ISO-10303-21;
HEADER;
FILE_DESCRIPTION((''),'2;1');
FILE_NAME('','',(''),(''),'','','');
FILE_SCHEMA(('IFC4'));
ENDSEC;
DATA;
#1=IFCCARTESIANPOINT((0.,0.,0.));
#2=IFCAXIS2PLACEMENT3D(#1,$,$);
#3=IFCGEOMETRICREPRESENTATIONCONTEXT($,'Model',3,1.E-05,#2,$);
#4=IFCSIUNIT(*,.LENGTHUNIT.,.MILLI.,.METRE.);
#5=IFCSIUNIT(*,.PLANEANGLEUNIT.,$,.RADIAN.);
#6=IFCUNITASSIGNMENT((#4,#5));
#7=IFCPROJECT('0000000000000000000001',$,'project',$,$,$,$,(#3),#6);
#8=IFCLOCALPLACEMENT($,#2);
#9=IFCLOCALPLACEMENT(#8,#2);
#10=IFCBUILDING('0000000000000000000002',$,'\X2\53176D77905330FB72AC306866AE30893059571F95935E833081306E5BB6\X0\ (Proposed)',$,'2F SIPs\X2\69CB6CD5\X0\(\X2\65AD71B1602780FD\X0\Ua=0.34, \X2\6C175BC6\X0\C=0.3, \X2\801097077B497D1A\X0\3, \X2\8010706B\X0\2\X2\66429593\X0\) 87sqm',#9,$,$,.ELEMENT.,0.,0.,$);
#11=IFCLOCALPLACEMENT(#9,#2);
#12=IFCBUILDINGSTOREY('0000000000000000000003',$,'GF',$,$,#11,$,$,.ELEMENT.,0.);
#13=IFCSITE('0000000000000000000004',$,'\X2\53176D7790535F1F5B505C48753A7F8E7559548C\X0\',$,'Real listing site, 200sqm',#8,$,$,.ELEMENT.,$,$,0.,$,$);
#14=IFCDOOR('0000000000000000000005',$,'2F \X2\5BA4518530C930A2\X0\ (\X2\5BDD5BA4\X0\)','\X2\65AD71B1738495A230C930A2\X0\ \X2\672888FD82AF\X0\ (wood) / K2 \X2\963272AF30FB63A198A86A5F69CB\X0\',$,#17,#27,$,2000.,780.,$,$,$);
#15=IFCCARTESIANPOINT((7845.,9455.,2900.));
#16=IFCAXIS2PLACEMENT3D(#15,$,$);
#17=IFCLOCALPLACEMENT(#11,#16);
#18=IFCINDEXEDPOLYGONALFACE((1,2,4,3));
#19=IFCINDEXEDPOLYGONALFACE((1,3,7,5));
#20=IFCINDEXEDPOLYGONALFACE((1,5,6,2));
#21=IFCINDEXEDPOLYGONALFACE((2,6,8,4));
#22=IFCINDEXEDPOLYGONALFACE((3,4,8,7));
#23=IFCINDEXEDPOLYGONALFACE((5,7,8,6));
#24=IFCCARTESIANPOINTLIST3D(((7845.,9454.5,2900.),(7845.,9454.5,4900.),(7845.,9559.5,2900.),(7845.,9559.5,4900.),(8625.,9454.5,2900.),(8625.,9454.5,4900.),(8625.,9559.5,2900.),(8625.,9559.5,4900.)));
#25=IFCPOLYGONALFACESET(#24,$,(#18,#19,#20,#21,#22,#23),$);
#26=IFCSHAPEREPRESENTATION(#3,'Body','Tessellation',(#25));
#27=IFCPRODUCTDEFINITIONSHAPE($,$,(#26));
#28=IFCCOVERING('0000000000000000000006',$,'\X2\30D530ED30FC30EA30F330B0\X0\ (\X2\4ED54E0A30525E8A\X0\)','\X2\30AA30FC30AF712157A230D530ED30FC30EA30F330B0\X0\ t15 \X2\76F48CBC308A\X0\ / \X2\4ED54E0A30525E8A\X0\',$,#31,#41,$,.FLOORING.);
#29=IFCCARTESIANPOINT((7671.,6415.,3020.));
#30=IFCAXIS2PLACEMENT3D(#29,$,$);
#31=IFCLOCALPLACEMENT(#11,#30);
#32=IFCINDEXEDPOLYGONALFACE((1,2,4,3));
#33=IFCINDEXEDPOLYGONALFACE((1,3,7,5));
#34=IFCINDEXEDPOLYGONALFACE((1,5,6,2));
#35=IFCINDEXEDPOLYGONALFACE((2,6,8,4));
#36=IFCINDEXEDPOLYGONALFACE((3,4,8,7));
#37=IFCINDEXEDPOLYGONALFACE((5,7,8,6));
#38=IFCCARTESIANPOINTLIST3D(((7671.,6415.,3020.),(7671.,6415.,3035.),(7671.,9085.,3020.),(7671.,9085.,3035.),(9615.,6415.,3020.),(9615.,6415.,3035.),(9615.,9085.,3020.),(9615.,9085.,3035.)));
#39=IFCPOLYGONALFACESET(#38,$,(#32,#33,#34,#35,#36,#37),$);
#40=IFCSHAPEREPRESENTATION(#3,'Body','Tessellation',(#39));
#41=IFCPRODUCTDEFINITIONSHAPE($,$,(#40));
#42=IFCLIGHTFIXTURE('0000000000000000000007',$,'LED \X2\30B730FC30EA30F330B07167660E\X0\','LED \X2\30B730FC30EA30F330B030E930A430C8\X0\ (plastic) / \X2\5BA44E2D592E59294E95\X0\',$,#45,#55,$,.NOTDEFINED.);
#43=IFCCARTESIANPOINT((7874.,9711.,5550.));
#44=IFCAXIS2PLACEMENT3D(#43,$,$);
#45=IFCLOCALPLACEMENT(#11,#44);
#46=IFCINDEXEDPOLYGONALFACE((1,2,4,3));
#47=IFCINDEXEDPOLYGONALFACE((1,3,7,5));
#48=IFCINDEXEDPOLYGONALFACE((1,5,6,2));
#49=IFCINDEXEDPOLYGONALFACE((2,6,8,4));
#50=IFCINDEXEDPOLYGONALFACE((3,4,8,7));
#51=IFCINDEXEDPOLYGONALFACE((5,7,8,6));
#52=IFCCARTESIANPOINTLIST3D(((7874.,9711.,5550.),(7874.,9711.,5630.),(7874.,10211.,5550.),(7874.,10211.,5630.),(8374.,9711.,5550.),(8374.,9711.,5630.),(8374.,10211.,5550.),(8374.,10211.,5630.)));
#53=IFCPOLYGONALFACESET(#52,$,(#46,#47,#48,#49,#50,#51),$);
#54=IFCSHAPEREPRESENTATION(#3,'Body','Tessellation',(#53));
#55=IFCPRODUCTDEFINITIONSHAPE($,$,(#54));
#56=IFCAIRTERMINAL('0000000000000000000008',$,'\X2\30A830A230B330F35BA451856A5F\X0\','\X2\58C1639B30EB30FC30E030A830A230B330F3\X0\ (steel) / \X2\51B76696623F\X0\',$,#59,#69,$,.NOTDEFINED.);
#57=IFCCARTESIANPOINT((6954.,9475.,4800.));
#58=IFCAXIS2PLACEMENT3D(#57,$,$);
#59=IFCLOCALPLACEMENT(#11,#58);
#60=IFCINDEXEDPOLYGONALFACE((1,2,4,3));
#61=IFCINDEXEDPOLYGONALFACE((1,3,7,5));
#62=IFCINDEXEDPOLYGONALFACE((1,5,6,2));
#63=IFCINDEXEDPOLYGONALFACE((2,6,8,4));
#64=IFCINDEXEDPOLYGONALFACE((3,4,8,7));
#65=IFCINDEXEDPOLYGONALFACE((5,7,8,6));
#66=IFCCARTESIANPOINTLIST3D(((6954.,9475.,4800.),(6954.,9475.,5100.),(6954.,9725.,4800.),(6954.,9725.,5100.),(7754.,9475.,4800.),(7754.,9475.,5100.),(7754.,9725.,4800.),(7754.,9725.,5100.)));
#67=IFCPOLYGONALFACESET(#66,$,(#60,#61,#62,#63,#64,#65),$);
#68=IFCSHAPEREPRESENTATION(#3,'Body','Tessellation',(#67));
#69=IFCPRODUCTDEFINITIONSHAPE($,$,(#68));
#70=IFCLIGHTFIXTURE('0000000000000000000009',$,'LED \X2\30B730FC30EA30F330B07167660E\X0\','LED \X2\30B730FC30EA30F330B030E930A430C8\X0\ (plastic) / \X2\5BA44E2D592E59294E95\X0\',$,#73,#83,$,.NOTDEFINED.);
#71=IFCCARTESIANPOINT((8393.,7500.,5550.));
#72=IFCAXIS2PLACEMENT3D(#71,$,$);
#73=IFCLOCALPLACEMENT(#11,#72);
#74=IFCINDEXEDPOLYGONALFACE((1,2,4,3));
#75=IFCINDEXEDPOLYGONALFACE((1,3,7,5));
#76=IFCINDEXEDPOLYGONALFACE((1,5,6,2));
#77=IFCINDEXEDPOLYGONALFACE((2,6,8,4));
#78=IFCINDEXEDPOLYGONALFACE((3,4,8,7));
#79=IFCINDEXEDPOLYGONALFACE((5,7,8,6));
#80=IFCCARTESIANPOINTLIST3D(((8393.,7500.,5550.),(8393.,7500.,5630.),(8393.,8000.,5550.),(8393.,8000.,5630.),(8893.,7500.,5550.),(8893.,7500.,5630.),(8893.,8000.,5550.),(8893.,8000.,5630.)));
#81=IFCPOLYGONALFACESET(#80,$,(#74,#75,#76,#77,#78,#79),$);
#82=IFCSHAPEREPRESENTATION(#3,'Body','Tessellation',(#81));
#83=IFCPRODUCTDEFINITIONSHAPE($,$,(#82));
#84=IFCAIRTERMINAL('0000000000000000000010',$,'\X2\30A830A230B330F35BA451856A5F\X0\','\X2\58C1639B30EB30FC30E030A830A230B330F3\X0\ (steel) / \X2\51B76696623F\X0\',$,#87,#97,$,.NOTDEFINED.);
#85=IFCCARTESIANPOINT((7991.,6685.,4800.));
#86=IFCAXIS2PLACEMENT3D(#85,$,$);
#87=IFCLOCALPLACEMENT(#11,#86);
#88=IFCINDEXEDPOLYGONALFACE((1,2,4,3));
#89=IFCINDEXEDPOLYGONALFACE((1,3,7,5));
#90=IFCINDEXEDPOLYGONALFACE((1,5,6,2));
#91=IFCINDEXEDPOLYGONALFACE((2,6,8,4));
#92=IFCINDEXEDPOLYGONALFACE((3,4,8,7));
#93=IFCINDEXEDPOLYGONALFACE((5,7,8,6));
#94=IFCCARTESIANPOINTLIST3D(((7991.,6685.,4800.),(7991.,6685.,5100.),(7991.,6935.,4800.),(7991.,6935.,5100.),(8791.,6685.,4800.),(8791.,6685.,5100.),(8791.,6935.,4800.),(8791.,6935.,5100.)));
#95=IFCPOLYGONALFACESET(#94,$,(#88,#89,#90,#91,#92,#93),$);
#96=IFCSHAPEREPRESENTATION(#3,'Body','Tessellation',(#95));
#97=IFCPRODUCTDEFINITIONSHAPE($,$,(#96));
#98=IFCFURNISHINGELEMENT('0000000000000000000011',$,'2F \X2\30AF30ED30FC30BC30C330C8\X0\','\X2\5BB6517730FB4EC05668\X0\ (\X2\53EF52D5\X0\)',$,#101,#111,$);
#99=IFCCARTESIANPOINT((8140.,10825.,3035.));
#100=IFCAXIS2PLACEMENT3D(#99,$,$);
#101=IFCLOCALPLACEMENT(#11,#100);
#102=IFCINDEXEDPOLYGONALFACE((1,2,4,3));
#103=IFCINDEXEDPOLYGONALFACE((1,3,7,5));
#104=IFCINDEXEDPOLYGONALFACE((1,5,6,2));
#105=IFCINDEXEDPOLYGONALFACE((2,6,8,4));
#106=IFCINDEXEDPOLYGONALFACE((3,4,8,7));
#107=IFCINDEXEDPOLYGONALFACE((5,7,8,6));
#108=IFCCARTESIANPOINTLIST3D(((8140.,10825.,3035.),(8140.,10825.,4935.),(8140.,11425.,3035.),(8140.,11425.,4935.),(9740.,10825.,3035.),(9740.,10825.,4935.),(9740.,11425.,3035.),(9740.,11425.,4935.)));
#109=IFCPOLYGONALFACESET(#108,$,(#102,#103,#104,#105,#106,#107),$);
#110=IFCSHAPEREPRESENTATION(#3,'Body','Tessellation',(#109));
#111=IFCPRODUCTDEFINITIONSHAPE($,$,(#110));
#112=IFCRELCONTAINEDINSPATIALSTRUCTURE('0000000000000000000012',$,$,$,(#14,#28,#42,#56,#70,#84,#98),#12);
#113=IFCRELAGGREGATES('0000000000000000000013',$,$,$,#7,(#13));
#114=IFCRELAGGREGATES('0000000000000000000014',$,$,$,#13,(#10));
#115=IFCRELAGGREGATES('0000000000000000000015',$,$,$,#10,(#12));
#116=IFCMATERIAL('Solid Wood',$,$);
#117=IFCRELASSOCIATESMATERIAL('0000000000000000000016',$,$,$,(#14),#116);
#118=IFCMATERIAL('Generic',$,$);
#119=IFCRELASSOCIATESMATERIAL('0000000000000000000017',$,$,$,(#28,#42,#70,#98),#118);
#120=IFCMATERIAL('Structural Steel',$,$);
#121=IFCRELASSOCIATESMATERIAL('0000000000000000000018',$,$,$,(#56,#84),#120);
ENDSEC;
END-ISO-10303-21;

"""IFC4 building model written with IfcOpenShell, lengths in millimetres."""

from ifc_helpers import new_model, si_unit, frame, frame_2d, origin, place, context, project, spatial, rectangle, extrude, material, element, save


model = new_model("IFC4")

# Units and contexts
model_context = context("Model", 3, precision=1e-05, world=origin())
ifc_project = project(units=[si_unit("LENGTHUNIT", "METRE", prefix="MILLI"), si_unit("PLANEANGLEUNIT", "RADIAN")], contexts=[model_context])

# Site, building, storey
site_placement = place(None, origin())
site = spatial("IfcSite", under=ifc_project, at=site_placement, Name="北海道弟子屈町美留和", ObjectType="Real listing site, 200sqm", CompositionType="ELEMENT", RefElevation=0.0)
building_placement = place(site_placement, origin())
building = spatial("IfcBuilding", under=site, at=building_placement, Name="北海道・犬と暮らす土間広めの家 (Proposed)", ObjectType="2F SIPs構法(断熱性能Ua=0.34, 気密C=0.3, 耐震等級3, 耐火2時間) 87sqm", CompositionType="ELEMENT", ElevationOfRefHeight=0.0, ElevationOfTerrain=0.0)
storey_placement = place(building_placement, origin())
storey = spatial("IfcBuildingStorey", under=building, at=storey_placement, Name="GF", CompositionType="ELEMENT", Elevation=0.0)

# Shared definitions
ifc_material_1 = material(Name="Solid Wood")

# Door
door_placement = place(storey_placement, frame((7845.0, 9455.0, 2900.0)))
element("IfcDoor", 1, at=door_placement, inside=storey, material=ifc_material_1, Name="2F 室内ドア (寝室)", Description="断熱玄関ドア 木製芯 (wood) / K2 防犯・採風機構", OverallHeight=2000.0, OverallWidth=780.0, context=model_context, shape_type="SweptSolid", body=[
    extrude(rectangle(XDim=780.0, YDim=105.0, at=frame_2d((390.0, 52.0))), frame((7845.0, 9455.0, 2900.0)), (0.0, 0.0, 1.0), 2000.0),
])

# Covering
ifc_material_2 = material(Name="Generic")
covering_placement = place(storey_placement, frame((7671.0, 6415.0, 3020.0)))
element("IfcCovering", 2, at=covering_placement, inside=storey, material=ifc_material_2, Name="フローリング (仕上げ床)", Description="オーク無垢フローリング t15 直貼り / 仕上げ床", PredefinedType="FLOORING", context=model_context, shape_type="SweptSolid", body=[
    extrude(rectangle(XDim=1944.0, YDim=2670.0, at=frame_2d((972.0, 1335.0))), frame((7671.0, 6415.0, 3020.0)), (0.0, 0.0, 1.0), 15.0),
])

# Light fixture
light_fixture_1_placement = place(storey_placement, frame((7874.0, 9711.0, 5550.0)))
element("IfcLightFixture", 3, at=light_fixture_1_placement, inside=storey, material=ifc_material_2, Name="LED シーリング照明", Description="LED シーリングライト (plastic) / 室中央天井", PredefinedType="NOTDEFINED", context=model_context, shape_type="SweptSolid", body=[
    extrude(rectangle(XDim=500.0, YDim=500.0, at=frame_2d((250.0, 250.0))), frame((7874.0, 9711.0, 5550.0)), (0.0, 0.0, 1.0), 80.0),
])

# Air terminal
ifc_material_3 = material(Name="Structural Steel")
air_terminal_1_placement = place(storey_placement, frame((6954.0, 9475.0, 4800.0)))
element("IfcAirTerminal", 4, at=air_terminal_1_placement, inside=storey, material=ifc_material_3, Name="エアコン室内機", Description="壁掛ルームエアコン (steel) / 冷暖房", PredefinedType="NOTDEFINED", context=model_context, shape_type="SweptSolid", body=[
    extrude(rectangle(XDim=800.0, YDim=250.0, at=frame_2d((400.0, 125.0))), frame((6954.0, 9475.0, 4800.0)), (0.0, 0.0, 1.0), 300.0),
])

# Light fixture
light_fixture_2_placement = place(storey_placement, frame((8393.0, 7500.0, 5550.0)))
element("IfcLightFixture", 5, at=light_fixture_2_placement, inside=storey, material=ifc_material_2, Name="LED シーリング照明", Description="LED シーリングライト (plastic) / 室中央天井", PredefinedType="NOTDEFINED", context=model_context, shape_type="SweptSolid", body=[
    extrude(rectangle(XDim=500.0, YDim=500.0, at=frame_2d((250.0, 250.0))), frame((8393.0, 7500.0, 5550.0)), (0.0, 0.0, 1.0), 80.0),
])

# Air terminal
air_terminal_2_placement = place(storey_placement, frame((7991.0, 6685.0, 4800.0)))
element("IfcAirTerminal", 6, at=air_terminal_2_placement, inside=storey, material=ifc_material_3, Name="エアコン室内機", Description="壁掛ルームエアコン (steel) / 冷暖房", PredefinedType="NOTDEFINED", context=model_context, shape_type="SweptSolid", body=[
    extrude(rectangle(XDim=800.0, YDim=250.0, at=frame_2d((400.0, 125.0))), frame((7991.0, 6685.0, 4800.0)), (0.0, 0.0, 1.0), 300.0),
])

# Furnishing element
furnishing_placement = place(storey_placement, frame((8140.0, 10825.0, 3035.0)))
element("IfcFurnishingElement", 7, at=furnishing_placement, inside=storey, material=ifc_material_2, Name="2F クローゼット", Description="家具・什器 (可動)", context=model_context, shape_type="SweptSolid", body=[
    extrude(rectangle(XDim=1600.0, YDim=600.0, at=frame_2d((800.0, 300.0))), frame((8140.0, 10825.0, 3035.0)), (0.0, 0.0, 1.0), 1900.0),
])

save(model, "model.ifc")
